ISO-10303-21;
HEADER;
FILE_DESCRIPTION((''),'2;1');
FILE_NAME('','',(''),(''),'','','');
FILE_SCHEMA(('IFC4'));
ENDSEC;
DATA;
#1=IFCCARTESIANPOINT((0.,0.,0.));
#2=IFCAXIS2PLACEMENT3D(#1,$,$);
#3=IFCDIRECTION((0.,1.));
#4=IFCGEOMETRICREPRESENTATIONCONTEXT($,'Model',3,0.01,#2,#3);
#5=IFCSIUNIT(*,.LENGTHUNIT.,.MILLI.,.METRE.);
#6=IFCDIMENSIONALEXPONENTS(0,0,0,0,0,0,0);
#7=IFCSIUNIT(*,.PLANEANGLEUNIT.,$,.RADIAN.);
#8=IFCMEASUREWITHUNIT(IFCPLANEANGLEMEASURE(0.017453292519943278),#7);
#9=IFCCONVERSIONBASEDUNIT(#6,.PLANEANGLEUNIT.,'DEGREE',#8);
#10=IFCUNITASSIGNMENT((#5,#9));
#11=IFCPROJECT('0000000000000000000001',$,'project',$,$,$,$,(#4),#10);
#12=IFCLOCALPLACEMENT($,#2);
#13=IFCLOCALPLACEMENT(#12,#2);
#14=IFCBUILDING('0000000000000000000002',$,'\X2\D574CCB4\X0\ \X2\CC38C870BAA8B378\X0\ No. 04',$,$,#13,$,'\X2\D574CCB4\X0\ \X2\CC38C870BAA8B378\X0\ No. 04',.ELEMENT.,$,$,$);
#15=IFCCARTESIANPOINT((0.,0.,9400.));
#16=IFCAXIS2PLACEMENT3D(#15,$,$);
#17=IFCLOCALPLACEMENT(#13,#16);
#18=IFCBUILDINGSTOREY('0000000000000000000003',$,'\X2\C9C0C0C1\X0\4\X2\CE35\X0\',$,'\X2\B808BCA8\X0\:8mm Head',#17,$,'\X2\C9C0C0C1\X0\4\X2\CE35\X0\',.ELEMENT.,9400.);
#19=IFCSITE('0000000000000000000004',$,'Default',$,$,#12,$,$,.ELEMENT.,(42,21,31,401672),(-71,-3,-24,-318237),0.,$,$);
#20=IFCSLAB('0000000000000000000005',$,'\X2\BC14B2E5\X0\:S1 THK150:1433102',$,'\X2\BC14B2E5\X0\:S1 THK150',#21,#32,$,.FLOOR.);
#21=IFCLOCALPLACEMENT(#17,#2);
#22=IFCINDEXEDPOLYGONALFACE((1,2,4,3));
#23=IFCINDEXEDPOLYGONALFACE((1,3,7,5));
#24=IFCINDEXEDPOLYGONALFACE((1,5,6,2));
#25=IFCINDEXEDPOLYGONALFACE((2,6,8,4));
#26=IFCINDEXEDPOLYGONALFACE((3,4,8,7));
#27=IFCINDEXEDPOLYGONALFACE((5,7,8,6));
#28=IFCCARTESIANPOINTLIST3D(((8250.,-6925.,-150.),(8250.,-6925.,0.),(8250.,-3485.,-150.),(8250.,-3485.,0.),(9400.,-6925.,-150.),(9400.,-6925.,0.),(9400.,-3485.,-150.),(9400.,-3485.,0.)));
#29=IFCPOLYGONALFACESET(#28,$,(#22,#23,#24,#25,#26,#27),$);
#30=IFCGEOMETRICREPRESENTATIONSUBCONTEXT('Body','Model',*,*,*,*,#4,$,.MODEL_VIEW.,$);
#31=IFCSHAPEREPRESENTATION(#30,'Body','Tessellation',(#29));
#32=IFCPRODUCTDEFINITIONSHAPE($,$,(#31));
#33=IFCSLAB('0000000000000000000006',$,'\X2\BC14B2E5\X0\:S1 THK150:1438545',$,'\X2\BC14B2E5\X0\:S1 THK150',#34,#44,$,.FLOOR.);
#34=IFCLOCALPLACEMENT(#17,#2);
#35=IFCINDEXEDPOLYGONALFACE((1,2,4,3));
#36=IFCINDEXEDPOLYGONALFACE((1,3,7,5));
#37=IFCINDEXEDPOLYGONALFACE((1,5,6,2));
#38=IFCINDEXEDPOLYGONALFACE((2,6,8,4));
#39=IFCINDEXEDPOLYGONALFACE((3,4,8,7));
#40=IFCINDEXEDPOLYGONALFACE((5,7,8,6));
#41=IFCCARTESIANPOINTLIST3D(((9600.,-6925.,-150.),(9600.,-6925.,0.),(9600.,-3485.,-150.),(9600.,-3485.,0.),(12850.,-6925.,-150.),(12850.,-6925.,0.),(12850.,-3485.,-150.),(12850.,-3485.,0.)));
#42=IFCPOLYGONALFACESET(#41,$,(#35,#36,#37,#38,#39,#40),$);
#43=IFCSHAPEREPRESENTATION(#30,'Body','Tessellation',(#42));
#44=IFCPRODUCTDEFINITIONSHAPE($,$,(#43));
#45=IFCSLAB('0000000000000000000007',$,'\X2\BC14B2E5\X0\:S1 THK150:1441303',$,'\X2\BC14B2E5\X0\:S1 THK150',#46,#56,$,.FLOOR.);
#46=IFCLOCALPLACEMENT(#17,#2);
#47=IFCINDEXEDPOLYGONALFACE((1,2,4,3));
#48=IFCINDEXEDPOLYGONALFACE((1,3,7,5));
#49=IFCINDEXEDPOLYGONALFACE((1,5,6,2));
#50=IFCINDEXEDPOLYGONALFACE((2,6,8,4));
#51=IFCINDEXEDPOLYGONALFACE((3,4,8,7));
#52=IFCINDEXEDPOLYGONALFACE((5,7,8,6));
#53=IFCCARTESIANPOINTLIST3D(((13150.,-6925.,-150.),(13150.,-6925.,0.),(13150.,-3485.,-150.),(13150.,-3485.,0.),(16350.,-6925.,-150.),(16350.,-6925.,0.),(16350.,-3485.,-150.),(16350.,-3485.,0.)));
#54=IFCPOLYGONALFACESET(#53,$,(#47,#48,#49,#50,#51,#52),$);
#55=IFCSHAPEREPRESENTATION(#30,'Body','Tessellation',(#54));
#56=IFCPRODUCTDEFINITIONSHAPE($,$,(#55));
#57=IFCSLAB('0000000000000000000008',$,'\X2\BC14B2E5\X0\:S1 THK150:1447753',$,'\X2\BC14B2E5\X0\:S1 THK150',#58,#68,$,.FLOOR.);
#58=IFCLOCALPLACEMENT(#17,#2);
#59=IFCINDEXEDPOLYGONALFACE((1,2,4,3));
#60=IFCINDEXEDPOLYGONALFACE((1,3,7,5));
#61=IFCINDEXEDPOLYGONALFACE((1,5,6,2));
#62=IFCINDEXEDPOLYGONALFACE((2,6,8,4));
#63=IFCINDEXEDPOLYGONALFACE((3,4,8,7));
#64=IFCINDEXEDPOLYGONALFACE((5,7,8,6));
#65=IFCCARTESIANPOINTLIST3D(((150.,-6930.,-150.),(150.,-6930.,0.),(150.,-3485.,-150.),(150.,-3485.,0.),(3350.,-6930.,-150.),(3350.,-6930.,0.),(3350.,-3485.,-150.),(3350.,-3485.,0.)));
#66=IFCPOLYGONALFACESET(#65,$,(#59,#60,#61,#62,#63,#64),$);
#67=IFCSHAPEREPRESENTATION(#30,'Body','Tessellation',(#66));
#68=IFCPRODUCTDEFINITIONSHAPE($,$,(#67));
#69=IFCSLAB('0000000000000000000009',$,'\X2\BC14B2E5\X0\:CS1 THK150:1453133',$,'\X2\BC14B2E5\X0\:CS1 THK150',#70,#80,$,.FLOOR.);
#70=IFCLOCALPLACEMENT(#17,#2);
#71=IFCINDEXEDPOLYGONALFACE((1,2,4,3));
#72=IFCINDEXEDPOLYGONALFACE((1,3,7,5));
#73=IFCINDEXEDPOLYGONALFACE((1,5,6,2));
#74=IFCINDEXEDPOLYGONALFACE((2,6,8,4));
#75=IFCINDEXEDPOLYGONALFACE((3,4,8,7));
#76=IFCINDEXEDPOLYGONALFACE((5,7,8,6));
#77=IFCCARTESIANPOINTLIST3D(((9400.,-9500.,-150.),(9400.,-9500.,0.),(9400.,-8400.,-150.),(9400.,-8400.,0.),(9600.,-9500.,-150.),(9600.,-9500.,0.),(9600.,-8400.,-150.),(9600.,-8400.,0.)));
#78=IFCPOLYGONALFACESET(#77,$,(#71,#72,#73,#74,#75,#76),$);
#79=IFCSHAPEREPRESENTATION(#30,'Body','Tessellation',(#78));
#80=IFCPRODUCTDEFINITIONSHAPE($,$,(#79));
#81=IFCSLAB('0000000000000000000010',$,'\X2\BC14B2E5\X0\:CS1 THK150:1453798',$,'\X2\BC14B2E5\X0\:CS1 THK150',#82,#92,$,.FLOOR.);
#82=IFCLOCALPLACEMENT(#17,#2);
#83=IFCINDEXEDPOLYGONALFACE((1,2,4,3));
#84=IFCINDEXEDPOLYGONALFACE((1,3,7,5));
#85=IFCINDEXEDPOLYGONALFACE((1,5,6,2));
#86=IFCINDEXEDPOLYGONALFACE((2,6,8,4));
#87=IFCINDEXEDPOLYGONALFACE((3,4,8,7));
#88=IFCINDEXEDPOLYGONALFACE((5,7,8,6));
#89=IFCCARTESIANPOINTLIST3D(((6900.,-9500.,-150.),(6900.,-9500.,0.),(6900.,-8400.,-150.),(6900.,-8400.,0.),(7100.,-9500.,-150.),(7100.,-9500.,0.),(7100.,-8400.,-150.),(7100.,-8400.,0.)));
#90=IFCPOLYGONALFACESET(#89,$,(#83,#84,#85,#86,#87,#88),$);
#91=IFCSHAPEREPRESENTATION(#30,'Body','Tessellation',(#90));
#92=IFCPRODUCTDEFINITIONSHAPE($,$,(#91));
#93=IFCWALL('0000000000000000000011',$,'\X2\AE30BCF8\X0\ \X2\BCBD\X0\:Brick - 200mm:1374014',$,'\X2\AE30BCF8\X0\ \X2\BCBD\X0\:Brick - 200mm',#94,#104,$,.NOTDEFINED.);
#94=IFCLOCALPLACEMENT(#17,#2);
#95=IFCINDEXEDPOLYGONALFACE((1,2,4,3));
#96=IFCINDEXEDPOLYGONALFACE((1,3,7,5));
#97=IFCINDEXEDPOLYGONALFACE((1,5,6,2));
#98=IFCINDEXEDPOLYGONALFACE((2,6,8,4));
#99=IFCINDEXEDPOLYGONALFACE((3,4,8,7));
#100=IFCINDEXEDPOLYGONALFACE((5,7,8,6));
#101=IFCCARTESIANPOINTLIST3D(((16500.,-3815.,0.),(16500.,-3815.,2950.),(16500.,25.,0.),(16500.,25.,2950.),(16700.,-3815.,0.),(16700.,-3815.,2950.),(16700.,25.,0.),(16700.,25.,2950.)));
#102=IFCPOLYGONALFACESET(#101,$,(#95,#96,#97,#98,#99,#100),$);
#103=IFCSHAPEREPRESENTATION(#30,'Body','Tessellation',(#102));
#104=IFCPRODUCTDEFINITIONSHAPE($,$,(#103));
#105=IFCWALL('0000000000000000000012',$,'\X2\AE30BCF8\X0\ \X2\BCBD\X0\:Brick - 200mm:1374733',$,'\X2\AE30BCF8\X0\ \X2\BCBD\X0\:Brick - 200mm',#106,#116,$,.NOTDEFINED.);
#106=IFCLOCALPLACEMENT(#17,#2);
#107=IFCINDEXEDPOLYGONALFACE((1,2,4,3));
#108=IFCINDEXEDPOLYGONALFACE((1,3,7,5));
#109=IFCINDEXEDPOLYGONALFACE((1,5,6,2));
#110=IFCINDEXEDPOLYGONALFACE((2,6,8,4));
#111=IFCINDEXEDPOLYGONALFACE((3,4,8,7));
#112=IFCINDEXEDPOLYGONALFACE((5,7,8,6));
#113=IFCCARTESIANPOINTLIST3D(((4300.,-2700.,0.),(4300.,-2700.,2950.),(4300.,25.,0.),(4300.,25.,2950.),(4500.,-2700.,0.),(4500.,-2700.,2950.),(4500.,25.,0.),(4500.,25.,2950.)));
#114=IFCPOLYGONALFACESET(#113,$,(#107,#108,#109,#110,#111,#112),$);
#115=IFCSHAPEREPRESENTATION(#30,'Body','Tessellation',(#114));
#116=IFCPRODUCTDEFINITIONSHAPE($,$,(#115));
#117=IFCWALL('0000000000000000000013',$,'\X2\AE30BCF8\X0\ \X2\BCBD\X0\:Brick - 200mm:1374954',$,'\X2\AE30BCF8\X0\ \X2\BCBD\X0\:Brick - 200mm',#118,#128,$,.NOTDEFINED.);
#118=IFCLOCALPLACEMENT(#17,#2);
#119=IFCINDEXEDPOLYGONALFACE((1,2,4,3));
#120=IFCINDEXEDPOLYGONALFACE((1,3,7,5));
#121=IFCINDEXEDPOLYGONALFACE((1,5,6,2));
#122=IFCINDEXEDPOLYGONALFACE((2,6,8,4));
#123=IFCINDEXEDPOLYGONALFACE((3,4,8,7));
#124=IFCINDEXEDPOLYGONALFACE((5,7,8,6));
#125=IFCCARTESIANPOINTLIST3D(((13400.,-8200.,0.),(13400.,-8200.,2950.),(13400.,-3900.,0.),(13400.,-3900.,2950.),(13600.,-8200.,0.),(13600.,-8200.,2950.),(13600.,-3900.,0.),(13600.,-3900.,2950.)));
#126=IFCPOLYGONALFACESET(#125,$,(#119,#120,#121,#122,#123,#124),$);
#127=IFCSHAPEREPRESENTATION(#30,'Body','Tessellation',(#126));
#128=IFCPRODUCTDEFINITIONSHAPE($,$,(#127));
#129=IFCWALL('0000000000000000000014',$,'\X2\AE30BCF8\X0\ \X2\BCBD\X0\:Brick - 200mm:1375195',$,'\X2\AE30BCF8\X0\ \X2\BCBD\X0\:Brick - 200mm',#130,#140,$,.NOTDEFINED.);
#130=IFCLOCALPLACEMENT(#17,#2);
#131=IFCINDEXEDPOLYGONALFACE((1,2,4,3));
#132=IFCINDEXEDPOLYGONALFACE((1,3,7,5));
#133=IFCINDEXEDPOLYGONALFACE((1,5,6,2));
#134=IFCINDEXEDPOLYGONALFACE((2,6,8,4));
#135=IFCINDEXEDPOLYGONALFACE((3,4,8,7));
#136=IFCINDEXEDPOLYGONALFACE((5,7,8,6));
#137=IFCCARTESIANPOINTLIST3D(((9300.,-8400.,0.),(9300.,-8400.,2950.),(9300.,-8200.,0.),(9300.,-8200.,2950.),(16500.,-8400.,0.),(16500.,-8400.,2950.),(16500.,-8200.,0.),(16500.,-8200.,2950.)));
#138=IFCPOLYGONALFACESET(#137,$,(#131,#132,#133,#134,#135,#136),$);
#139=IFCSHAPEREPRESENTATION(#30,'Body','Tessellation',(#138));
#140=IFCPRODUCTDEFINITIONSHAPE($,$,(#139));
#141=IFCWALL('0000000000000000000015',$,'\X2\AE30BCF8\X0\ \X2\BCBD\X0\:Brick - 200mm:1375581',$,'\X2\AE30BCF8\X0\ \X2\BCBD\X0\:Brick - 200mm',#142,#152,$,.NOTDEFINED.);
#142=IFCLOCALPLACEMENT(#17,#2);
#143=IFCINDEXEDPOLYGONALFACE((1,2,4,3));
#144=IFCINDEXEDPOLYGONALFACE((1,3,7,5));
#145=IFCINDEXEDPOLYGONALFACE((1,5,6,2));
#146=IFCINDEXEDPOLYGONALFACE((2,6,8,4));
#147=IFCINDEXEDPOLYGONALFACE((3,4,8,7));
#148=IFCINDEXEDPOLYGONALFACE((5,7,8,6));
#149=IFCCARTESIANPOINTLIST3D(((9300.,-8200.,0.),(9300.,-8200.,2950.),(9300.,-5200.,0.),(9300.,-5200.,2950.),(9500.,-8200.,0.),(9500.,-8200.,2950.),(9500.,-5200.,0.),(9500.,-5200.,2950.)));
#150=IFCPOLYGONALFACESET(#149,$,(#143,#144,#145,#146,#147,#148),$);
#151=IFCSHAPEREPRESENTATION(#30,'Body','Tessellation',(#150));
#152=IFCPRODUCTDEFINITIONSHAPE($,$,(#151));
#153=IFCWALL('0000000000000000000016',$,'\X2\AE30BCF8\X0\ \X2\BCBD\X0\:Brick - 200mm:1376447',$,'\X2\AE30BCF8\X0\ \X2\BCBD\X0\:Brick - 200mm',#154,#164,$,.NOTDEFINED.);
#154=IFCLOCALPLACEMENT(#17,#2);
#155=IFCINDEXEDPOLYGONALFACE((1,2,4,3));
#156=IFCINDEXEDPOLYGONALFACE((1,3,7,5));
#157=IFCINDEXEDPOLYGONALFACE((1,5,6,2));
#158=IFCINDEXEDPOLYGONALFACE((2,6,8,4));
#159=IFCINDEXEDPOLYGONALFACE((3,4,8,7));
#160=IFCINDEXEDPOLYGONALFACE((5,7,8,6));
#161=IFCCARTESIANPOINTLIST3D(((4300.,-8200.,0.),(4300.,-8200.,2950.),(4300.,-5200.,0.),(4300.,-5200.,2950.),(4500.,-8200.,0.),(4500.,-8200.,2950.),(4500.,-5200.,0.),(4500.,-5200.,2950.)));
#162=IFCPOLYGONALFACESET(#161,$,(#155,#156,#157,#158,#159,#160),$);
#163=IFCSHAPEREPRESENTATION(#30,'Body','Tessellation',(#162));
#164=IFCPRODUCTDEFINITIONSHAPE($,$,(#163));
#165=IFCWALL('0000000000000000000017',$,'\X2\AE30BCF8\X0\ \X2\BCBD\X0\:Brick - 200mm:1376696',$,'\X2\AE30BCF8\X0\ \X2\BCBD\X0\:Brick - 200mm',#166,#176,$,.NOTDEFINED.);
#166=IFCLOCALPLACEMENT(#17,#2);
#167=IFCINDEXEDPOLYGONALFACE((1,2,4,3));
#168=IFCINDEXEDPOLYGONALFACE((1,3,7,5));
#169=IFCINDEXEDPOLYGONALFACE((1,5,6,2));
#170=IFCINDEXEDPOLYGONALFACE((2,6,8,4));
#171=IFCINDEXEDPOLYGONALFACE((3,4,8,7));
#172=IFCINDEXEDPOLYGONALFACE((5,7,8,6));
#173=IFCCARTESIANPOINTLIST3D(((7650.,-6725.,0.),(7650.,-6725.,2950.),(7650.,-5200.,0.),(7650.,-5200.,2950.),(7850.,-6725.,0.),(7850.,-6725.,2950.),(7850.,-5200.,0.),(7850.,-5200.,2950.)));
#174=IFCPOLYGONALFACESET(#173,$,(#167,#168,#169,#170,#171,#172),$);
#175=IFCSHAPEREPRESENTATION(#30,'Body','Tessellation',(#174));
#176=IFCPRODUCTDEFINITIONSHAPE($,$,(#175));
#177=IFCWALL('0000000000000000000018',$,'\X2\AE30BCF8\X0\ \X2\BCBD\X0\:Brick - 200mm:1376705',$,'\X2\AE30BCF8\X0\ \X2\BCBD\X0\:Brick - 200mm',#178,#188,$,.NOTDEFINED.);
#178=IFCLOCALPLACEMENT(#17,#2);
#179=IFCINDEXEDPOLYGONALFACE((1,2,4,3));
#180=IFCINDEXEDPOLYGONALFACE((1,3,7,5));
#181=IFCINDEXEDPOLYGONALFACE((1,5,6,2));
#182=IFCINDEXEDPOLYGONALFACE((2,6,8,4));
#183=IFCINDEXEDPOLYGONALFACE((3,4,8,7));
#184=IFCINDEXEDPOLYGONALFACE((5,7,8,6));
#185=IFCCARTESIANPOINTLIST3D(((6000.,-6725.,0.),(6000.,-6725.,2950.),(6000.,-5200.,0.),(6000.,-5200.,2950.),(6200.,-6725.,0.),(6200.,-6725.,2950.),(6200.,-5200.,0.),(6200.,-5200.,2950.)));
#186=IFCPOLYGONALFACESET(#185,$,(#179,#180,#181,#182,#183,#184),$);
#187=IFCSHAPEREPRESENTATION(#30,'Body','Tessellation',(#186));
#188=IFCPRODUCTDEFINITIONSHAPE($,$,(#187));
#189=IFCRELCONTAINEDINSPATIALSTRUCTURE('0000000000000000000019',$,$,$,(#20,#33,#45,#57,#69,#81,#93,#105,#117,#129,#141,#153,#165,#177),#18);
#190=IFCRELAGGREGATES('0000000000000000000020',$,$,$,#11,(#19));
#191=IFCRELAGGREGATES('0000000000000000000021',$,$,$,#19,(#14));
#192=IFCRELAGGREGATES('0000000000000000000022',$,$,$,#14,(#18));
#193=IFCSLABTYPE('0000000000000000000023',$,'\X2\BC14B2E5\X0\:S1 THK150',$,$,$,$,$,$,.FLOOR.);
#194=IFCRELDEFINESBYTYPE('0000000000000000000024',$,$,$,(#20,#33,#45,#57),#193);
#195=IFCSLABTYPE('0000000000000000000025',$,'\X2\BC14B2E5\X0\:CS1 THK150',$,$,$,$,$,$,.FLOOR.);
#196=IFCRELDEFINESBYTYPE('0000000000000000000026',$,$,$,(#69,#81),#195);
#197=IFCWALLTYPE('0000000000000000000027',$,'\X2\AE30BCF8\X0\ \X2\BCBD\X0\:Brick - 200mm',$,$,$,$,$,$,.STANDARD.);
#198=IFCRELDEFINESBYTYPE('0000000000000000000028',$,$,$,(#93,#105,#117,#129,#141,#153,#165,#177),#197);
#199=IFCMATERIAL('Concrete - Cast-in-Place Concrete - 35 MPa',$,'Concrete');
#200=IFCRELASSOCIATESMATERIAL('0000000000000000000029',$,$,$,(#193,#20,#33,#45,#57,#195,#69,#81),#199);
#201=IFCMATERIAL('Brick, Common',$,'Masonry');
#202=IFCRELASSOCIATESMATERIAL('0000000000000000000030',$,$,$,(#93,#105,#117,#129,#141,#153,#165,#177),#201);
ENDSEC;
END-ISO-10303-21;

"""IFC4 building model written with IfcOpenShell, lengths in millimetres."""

from ifc_helpers import new_model, entity, si_unit, converted_unit, direction, frame, origin, place, context, subcontext, project, spatial, indexed_curve, outline, extrude, material, type_object, element, save


model = new_model("IFC4")

# Units and contexts
model_context = context("Model", 3, precision=0.01, world=origin(), true_north=direction((0.0, 1.0)))
body_context = subcontext(model_context, "Body", "Model", "MODEL_VIEW")
ifc_project = project(units=[si_unit("LENGTHUNIT", "METRE", prefix="MILLI"), converted_unit("PLANEANGLEUNIT", "DEGREE", entity("IfcPlaneAngleMeasure", 0.017453292519943278), si_unit("PLANEANGLEUNIT", "RADIAN"), dimensions=[0, 0, 0, 0, 0, 0, 0])], contexts=[model_context])

# Site, building, storey
site_placement = place(None, origin())
site = spatial("IfcSite", under=ifc_project, at=site_placement, Name="Default", CompositionType="ELEMENT", RefLatitude=(42, 21, 31, 401672), RefLongitude=(-71, -3, -24, -318237), RefElevation=0.0)
building_placement = place(site_placement, origin())
building = spatial("IfcBuilding", under=site, at=building_placement, Name="해체 참조모델 No. 04", LongName="해체 참조모델 No. 04", CompositionType="ELEMENT")
storey_placement = place(building_placement, frame((0.0, 0.0, 9400.0)))
storey = spatial("IfcBuildingStorey", under=building, at=storey_placement, Name="지상4층", ObjectType="레벨:8mm Head", LongName="지상4층", CompositionType="ELEMENT", Elevation=9400.0)

# Slabs
ifc_material_1 = material(Name="Concrete - Cast-in-Place Concrete - 35 MPa", Category="Concrete")
slab_type_1 = type_object("IfcSlabType", Name="바닥:S1 THK150", PredefinedType="FLOOR", material=ifc_material_1)
slab_1_placement = place(storey_placement, origin())
element("IfcSlab", 1, at=slab_1_placement, inside=storey, type_object=slab_type_1, material=ifc_material_1, Name="바닥:S1 THK150:1433102", ObjectType="바닥:S1 THK150", PredefinedType="FLOOR", context=body_context, shape_type="SweptSolid", body=[
    extrude(outline(indexed_curve([(-1720.0, -575.0), (1720.0, -575.0), (1720.0, 575.0), (-1720.0, 575.0), (-1720.0, -575.0)], self_intersect=False)), frame((8825.0, -5205.0, 0.0), z_axis=(0.0, 0.0, -1.0), x_axis=(0.0, 1.0, 0.0)), (0.0, 0.0, 1.0), 150.0),
])
slab_2_placement = place(storey_placement, origin())
element("IfcSlab", 2, at=slab_2_placement, inside=storey, type_object=slab_type_1, material=ifc_material_1, Name="바닥:S1 THK150:1438545", ObjectType="바닥:S1 THK150", PredefinedType="FLOOR", context=body_context, shape_type="SweptSolid", body=[
    extrude(outline(indexed_curve([(-1720.0, -1625.0), (1720.0, -1625.0), (1720.0, 1625.0), (-1720.0, 1625.0), (-1720.0, -1625.0)], self_intersect=False)), frame((11225.0, -5205.0, 0.0), z_axis=(0.0, 0.0, -1.0), x_axis=(0.0, 1.0, 0.0)), (0.0, 0.0, 1.0), 150.0),
])
slab_3_placement = place(storey_placement, origin())
element("IfcSlab", 3, at=slab_3_placement, inside=storey, type_object=slab_type_1, material=ifc_material_1, Name="바닥:S1 THK150:1441303", ObjectType="바닥:S1 THK150", PredefinedType="FLOOR", context=body_context, shape_type="SweptSolid", body=[
    extrude(outline(indexed_curve([(-1720.0, -1600.0), (1720.0, -1600.0), (1720.0, 1600.0), (-1720.0, 1600.0), (-1720.0, -1600.0)], self_intersect=False)), frame((14750.0, -5205.0, 0.0), z_axis=(0.0, 0.0, -1.0), x_axis=(0.0, 1.0, 0.0)), (0.0, 0.0, 1.0), 150.0),
])
slab_4_placement = place(storey_placement, origin())
element("IfcSlab", 4, at=slab_4_placement, inside=storey, type_object=slab_type_1, material=ifc_material_1, Name="바닥:S1 THK150:1447753", ObjectType="바닥:S1 THK150", PredefinedType="FLOOR", context=body_context, shape_type="SweptSolid", body=[
    extrude(outline(indexed_curve([(-1722.5, -1600.0), (1722.5, -1600.0), (1722.5, 1600.0), (-1722.5, 1600.0), (-1722.5, -1600.0)], self_intersect=False)), frame((1750.0, -5207.5, 0.0), z_axis=(0.0, 0.0, -1.0), x_axis=(0.0, 1.0, 0.0)), (0.0, 0.0, 1.0), 150.0),
])
slab_type_2 = type_object("IfcSlabType", Name="바닥:CS1 THK150", PredefinedType="FLOOR", material=ifc_material_1)
slab_5_placement = place(storey_placement, origin())
element("IfcSlab", 5, at=slab_5_placement, inside=storey, type_object=slab_type_2, material=ifc_material_1, Name="바닥:CS1 THK150:1453133", ObjectType="바닥:CS1 THK150", PredefinedType="FLOOR", context=body_context, shape_type="SweptSolid", body=[
    extrude(outline(indexed_curve([(-550.0, -100.0), (550.0, -100.0), (550.0, 100.0), (-550.0, 100.0), (-550.0, -100.0)], self_intersect=False)), frame((9500.0, -8950.0, 0.0), z_axis=(0.0, 0.0, -1.0), x_axis=(0.0, 1.0, 0.0)), (0.0, 0.0, 1.0), 150.0),
])
slab_6_placement = place(storey_placement, origin())
element("IfcSlab", 6, at=slab_6_placement, inside=storey, type_object=slab_type_2, material=ifc_material_1, Name="바닥:CS1 THK150:1453798", ObjectType="바닥:CS1 THK150", PredefinedType="FLOOR", context=body_context, shape_type="SweptSolid", body=[
    extrude(outline(indexed_curve([(-550.0, -100.0), (550.0, -100.0), (550.0, 100.0), (-550.0, 100.0), (-550.0, -100.0)], self_intersect=False)), frame((7000.0, -8950.0, 0.0), z_axis=(0.0, 0.0, -1.0), x_axis=(0.0, 1.0, 0.0)), (0.0, 0.0, 1.0), 150.0),
])

# Walls
ifc_material_2 = material(Name="Brick, Common", Category="Masonry")
wall_type = type_object("IfcWallType", Name="기본 벽:Brick - 200mm", PredefinedType="STANDARD")
wall_1_placement = place(storey_placement, frame((16600.0, 25.0, 0.0), z_axis=(0.0, 0.0, 1.0), x_axis=(0.0, -1.0, 0.0)))
element("IfcWall", 7, at=wall_1_placement, inside=storey, type_object=wall_type, material=ifc_material_2, Name="기본 벽:Brick - 200mm:1374014", ObjectType="기본 벽:Brick - 200mm", PredefinedType="NOTDEFINED", context=body_context, shape_type="SweptSolid", body=[
    extrude(outline(indexed_curve([(3840.0, 100.0), (0.0, 100.0), (0.0, -100.0), (3840.0, -100.0), (3840.0, 100.0)], self_intersect=False)), origin(), (0.0, 0.0, 1.0), 2950.0),
])
wall_2_placement = place(storey_placement, frame((4400.0, 25.0, 0.0), z_axis=(0.0, 0.0, 1.0), x_axis=(0.0, -1.0, 0.0)))
element("IfcWall", 8, at=wall_2_placement, inside=storey, type_object=wall_type, material=ifc_material_2, Name="기본 벽:Brick - 200mm:1374733", ObjectType="기본 벽:Brick - 200mm", PredefinedType="NOTDEFINED", context=body_context, shape_type="SweptSolid", body=[
    extrude(outline(indexed_curve([(2725.0, 100.0), (0.0, 100.0), (0.0, -100.0), (2725.0, -100.0), (2725.0, 100.0)], self_intersect=False)), origin(), (0.0, 0.0, 1.0), 2950.0),
])
wall_3_placement = place(storey_placement, frame((13500.0, -3900.0, 0.0), z_axis=(0.0, 0.0, 1.0), x_axis=(0.0, -1.0, 0.0)))
element("IfcWall", 9, at=wall_3_placement, inside=storey, type_object=wall_type, material=ifc_material_2, Name="기본 벽:Brick - 200mm:1374954", ObjectType="기본 벽:Brick - 200mm", PredefinedType="NOTDEFINED", context=body_context, shape_type="SweptSolid", body=[
    extrude(outline(indexed_curve([(4300.0, 100.0), (0.0, 100.0), (0.0, -100.0), (4300.0, -100.0), (4300.0, 100.0)], self_intersect=False)), origin(), (0.0, 0.0, 1.0), 2950.0),
])
wall_4_placement = place(storey_placement, frame((16500.0, -8300.0, 0.0), z_axis=(0.0, 0.0, 1.0), x_axis=(-1.0, 0.0, 0.0)))
element("IfcWall", 10, at=wall_4_placement, inside=storey, type_object=wall_type, material=ifc_material_2, Name="기본 벽:Brick - 200mm:1375195", ObjectType="기본 벽:Brick - 200mm", PredefinedType="NOTDEFINED", context=body_context, shape_type="SweptSolid", body=[
    extrude(outline(indexed_curve([(7200.0, 100.0), (0.0, 100.0), (0.0, -100.0), (7200.0, -100.0), (7200.0, 100.0)], self_intersect=False)), origin(), (0.0, 0.0, 1.0), 2950.0),
])
wall_5_placement = place(storey_placement, frame((9400.0, -8200.0, 0.0), z_axis=(0.0, 0.0, 1.0), x_axis=(0.0, 1.0, 0.0)))
element("IfcWall", 11, at=wall_5_placement, inside=storey, type_object=wall_type, material=ifc_material_2, Name="기본 벽:Brick - 200mm:1375581", ObjectType="기본 벽:Brick - 200mm", PredefinedType="NOTDEFINED", context=body_context, shape_type="SweptSolid", body=[
    extrude(outline(indexed_curve([(3000.0, 100.0), (0.0, 100.0), (0.0, -100.0), (3000.0, -100.0), (3000.0, 100.0)], self_intersect=False)), origin(), (0.0, 0.0, 1.0), 2950.0),
])
wall_6_placement = place(storey_placement, frame((4400.0, -8200.0, 0.0), z_axis=(0.0, 0.0, 1.0), x_axis=(0.0, 1.0, 0.0)))
element("IfcWall", 12, at=wall_6_placement, inside=storey, type_object=wall_type, material=ifc_material_2, Name="기본 벽:Brick - 200mm:1376447", ObjectType="기본 벽:Brick - 200mm", PredefinedType="NOTDEFINED", context=body_context, shape_type="SweptSolid", body=[
    extrude(outline(indexed_curve([(3000.0, 100.0), (0.0, 100.0), (0.0, -100.0), (3000.0, -100.0), (3000.0, 100.0)], self_intersect=False)), origin(), (0.0, 0.0, 1.0), 2950.0),
])
for number, where, z_axis, x_axis, name in (
    (13, (7750.0, -6725.0, 0.0), (0.0, 0.0, 1.0), (0.0, 1.0, 0.0), "기본 벽:Brick - 200mm:1376696"),
    (14, (6100.0, -6725.0, 0.0), (0.0, 0.0, 1.0), (0.0, 1.0, 0.0), "기본 벽:Brick - 200mm:1376705"),
):
    element("IfcWall", number, at=place(storey_placement, frame(where, z_axis=z_axis, x_axis=x_axis)), inside=storey, type_object=wall_type, material=ifc_material_2, Name=name, ObjectType="기본 벽:Brick - 200mm", PredefinedType="NOTDEFINED", context=body_context, shape_type="SweptSolid", body=[
        extrude(outline(indexed_curve([(1525.0, 100.0), (0.0, 100.0), (0.0, -100.0), (1525.0, -100.0), (1525.0, 100.0)], self_intersect=False)), origin(), (0.0, 0.0, 1.0), 2950.0),
    ])

save(model, "model.ifc")
